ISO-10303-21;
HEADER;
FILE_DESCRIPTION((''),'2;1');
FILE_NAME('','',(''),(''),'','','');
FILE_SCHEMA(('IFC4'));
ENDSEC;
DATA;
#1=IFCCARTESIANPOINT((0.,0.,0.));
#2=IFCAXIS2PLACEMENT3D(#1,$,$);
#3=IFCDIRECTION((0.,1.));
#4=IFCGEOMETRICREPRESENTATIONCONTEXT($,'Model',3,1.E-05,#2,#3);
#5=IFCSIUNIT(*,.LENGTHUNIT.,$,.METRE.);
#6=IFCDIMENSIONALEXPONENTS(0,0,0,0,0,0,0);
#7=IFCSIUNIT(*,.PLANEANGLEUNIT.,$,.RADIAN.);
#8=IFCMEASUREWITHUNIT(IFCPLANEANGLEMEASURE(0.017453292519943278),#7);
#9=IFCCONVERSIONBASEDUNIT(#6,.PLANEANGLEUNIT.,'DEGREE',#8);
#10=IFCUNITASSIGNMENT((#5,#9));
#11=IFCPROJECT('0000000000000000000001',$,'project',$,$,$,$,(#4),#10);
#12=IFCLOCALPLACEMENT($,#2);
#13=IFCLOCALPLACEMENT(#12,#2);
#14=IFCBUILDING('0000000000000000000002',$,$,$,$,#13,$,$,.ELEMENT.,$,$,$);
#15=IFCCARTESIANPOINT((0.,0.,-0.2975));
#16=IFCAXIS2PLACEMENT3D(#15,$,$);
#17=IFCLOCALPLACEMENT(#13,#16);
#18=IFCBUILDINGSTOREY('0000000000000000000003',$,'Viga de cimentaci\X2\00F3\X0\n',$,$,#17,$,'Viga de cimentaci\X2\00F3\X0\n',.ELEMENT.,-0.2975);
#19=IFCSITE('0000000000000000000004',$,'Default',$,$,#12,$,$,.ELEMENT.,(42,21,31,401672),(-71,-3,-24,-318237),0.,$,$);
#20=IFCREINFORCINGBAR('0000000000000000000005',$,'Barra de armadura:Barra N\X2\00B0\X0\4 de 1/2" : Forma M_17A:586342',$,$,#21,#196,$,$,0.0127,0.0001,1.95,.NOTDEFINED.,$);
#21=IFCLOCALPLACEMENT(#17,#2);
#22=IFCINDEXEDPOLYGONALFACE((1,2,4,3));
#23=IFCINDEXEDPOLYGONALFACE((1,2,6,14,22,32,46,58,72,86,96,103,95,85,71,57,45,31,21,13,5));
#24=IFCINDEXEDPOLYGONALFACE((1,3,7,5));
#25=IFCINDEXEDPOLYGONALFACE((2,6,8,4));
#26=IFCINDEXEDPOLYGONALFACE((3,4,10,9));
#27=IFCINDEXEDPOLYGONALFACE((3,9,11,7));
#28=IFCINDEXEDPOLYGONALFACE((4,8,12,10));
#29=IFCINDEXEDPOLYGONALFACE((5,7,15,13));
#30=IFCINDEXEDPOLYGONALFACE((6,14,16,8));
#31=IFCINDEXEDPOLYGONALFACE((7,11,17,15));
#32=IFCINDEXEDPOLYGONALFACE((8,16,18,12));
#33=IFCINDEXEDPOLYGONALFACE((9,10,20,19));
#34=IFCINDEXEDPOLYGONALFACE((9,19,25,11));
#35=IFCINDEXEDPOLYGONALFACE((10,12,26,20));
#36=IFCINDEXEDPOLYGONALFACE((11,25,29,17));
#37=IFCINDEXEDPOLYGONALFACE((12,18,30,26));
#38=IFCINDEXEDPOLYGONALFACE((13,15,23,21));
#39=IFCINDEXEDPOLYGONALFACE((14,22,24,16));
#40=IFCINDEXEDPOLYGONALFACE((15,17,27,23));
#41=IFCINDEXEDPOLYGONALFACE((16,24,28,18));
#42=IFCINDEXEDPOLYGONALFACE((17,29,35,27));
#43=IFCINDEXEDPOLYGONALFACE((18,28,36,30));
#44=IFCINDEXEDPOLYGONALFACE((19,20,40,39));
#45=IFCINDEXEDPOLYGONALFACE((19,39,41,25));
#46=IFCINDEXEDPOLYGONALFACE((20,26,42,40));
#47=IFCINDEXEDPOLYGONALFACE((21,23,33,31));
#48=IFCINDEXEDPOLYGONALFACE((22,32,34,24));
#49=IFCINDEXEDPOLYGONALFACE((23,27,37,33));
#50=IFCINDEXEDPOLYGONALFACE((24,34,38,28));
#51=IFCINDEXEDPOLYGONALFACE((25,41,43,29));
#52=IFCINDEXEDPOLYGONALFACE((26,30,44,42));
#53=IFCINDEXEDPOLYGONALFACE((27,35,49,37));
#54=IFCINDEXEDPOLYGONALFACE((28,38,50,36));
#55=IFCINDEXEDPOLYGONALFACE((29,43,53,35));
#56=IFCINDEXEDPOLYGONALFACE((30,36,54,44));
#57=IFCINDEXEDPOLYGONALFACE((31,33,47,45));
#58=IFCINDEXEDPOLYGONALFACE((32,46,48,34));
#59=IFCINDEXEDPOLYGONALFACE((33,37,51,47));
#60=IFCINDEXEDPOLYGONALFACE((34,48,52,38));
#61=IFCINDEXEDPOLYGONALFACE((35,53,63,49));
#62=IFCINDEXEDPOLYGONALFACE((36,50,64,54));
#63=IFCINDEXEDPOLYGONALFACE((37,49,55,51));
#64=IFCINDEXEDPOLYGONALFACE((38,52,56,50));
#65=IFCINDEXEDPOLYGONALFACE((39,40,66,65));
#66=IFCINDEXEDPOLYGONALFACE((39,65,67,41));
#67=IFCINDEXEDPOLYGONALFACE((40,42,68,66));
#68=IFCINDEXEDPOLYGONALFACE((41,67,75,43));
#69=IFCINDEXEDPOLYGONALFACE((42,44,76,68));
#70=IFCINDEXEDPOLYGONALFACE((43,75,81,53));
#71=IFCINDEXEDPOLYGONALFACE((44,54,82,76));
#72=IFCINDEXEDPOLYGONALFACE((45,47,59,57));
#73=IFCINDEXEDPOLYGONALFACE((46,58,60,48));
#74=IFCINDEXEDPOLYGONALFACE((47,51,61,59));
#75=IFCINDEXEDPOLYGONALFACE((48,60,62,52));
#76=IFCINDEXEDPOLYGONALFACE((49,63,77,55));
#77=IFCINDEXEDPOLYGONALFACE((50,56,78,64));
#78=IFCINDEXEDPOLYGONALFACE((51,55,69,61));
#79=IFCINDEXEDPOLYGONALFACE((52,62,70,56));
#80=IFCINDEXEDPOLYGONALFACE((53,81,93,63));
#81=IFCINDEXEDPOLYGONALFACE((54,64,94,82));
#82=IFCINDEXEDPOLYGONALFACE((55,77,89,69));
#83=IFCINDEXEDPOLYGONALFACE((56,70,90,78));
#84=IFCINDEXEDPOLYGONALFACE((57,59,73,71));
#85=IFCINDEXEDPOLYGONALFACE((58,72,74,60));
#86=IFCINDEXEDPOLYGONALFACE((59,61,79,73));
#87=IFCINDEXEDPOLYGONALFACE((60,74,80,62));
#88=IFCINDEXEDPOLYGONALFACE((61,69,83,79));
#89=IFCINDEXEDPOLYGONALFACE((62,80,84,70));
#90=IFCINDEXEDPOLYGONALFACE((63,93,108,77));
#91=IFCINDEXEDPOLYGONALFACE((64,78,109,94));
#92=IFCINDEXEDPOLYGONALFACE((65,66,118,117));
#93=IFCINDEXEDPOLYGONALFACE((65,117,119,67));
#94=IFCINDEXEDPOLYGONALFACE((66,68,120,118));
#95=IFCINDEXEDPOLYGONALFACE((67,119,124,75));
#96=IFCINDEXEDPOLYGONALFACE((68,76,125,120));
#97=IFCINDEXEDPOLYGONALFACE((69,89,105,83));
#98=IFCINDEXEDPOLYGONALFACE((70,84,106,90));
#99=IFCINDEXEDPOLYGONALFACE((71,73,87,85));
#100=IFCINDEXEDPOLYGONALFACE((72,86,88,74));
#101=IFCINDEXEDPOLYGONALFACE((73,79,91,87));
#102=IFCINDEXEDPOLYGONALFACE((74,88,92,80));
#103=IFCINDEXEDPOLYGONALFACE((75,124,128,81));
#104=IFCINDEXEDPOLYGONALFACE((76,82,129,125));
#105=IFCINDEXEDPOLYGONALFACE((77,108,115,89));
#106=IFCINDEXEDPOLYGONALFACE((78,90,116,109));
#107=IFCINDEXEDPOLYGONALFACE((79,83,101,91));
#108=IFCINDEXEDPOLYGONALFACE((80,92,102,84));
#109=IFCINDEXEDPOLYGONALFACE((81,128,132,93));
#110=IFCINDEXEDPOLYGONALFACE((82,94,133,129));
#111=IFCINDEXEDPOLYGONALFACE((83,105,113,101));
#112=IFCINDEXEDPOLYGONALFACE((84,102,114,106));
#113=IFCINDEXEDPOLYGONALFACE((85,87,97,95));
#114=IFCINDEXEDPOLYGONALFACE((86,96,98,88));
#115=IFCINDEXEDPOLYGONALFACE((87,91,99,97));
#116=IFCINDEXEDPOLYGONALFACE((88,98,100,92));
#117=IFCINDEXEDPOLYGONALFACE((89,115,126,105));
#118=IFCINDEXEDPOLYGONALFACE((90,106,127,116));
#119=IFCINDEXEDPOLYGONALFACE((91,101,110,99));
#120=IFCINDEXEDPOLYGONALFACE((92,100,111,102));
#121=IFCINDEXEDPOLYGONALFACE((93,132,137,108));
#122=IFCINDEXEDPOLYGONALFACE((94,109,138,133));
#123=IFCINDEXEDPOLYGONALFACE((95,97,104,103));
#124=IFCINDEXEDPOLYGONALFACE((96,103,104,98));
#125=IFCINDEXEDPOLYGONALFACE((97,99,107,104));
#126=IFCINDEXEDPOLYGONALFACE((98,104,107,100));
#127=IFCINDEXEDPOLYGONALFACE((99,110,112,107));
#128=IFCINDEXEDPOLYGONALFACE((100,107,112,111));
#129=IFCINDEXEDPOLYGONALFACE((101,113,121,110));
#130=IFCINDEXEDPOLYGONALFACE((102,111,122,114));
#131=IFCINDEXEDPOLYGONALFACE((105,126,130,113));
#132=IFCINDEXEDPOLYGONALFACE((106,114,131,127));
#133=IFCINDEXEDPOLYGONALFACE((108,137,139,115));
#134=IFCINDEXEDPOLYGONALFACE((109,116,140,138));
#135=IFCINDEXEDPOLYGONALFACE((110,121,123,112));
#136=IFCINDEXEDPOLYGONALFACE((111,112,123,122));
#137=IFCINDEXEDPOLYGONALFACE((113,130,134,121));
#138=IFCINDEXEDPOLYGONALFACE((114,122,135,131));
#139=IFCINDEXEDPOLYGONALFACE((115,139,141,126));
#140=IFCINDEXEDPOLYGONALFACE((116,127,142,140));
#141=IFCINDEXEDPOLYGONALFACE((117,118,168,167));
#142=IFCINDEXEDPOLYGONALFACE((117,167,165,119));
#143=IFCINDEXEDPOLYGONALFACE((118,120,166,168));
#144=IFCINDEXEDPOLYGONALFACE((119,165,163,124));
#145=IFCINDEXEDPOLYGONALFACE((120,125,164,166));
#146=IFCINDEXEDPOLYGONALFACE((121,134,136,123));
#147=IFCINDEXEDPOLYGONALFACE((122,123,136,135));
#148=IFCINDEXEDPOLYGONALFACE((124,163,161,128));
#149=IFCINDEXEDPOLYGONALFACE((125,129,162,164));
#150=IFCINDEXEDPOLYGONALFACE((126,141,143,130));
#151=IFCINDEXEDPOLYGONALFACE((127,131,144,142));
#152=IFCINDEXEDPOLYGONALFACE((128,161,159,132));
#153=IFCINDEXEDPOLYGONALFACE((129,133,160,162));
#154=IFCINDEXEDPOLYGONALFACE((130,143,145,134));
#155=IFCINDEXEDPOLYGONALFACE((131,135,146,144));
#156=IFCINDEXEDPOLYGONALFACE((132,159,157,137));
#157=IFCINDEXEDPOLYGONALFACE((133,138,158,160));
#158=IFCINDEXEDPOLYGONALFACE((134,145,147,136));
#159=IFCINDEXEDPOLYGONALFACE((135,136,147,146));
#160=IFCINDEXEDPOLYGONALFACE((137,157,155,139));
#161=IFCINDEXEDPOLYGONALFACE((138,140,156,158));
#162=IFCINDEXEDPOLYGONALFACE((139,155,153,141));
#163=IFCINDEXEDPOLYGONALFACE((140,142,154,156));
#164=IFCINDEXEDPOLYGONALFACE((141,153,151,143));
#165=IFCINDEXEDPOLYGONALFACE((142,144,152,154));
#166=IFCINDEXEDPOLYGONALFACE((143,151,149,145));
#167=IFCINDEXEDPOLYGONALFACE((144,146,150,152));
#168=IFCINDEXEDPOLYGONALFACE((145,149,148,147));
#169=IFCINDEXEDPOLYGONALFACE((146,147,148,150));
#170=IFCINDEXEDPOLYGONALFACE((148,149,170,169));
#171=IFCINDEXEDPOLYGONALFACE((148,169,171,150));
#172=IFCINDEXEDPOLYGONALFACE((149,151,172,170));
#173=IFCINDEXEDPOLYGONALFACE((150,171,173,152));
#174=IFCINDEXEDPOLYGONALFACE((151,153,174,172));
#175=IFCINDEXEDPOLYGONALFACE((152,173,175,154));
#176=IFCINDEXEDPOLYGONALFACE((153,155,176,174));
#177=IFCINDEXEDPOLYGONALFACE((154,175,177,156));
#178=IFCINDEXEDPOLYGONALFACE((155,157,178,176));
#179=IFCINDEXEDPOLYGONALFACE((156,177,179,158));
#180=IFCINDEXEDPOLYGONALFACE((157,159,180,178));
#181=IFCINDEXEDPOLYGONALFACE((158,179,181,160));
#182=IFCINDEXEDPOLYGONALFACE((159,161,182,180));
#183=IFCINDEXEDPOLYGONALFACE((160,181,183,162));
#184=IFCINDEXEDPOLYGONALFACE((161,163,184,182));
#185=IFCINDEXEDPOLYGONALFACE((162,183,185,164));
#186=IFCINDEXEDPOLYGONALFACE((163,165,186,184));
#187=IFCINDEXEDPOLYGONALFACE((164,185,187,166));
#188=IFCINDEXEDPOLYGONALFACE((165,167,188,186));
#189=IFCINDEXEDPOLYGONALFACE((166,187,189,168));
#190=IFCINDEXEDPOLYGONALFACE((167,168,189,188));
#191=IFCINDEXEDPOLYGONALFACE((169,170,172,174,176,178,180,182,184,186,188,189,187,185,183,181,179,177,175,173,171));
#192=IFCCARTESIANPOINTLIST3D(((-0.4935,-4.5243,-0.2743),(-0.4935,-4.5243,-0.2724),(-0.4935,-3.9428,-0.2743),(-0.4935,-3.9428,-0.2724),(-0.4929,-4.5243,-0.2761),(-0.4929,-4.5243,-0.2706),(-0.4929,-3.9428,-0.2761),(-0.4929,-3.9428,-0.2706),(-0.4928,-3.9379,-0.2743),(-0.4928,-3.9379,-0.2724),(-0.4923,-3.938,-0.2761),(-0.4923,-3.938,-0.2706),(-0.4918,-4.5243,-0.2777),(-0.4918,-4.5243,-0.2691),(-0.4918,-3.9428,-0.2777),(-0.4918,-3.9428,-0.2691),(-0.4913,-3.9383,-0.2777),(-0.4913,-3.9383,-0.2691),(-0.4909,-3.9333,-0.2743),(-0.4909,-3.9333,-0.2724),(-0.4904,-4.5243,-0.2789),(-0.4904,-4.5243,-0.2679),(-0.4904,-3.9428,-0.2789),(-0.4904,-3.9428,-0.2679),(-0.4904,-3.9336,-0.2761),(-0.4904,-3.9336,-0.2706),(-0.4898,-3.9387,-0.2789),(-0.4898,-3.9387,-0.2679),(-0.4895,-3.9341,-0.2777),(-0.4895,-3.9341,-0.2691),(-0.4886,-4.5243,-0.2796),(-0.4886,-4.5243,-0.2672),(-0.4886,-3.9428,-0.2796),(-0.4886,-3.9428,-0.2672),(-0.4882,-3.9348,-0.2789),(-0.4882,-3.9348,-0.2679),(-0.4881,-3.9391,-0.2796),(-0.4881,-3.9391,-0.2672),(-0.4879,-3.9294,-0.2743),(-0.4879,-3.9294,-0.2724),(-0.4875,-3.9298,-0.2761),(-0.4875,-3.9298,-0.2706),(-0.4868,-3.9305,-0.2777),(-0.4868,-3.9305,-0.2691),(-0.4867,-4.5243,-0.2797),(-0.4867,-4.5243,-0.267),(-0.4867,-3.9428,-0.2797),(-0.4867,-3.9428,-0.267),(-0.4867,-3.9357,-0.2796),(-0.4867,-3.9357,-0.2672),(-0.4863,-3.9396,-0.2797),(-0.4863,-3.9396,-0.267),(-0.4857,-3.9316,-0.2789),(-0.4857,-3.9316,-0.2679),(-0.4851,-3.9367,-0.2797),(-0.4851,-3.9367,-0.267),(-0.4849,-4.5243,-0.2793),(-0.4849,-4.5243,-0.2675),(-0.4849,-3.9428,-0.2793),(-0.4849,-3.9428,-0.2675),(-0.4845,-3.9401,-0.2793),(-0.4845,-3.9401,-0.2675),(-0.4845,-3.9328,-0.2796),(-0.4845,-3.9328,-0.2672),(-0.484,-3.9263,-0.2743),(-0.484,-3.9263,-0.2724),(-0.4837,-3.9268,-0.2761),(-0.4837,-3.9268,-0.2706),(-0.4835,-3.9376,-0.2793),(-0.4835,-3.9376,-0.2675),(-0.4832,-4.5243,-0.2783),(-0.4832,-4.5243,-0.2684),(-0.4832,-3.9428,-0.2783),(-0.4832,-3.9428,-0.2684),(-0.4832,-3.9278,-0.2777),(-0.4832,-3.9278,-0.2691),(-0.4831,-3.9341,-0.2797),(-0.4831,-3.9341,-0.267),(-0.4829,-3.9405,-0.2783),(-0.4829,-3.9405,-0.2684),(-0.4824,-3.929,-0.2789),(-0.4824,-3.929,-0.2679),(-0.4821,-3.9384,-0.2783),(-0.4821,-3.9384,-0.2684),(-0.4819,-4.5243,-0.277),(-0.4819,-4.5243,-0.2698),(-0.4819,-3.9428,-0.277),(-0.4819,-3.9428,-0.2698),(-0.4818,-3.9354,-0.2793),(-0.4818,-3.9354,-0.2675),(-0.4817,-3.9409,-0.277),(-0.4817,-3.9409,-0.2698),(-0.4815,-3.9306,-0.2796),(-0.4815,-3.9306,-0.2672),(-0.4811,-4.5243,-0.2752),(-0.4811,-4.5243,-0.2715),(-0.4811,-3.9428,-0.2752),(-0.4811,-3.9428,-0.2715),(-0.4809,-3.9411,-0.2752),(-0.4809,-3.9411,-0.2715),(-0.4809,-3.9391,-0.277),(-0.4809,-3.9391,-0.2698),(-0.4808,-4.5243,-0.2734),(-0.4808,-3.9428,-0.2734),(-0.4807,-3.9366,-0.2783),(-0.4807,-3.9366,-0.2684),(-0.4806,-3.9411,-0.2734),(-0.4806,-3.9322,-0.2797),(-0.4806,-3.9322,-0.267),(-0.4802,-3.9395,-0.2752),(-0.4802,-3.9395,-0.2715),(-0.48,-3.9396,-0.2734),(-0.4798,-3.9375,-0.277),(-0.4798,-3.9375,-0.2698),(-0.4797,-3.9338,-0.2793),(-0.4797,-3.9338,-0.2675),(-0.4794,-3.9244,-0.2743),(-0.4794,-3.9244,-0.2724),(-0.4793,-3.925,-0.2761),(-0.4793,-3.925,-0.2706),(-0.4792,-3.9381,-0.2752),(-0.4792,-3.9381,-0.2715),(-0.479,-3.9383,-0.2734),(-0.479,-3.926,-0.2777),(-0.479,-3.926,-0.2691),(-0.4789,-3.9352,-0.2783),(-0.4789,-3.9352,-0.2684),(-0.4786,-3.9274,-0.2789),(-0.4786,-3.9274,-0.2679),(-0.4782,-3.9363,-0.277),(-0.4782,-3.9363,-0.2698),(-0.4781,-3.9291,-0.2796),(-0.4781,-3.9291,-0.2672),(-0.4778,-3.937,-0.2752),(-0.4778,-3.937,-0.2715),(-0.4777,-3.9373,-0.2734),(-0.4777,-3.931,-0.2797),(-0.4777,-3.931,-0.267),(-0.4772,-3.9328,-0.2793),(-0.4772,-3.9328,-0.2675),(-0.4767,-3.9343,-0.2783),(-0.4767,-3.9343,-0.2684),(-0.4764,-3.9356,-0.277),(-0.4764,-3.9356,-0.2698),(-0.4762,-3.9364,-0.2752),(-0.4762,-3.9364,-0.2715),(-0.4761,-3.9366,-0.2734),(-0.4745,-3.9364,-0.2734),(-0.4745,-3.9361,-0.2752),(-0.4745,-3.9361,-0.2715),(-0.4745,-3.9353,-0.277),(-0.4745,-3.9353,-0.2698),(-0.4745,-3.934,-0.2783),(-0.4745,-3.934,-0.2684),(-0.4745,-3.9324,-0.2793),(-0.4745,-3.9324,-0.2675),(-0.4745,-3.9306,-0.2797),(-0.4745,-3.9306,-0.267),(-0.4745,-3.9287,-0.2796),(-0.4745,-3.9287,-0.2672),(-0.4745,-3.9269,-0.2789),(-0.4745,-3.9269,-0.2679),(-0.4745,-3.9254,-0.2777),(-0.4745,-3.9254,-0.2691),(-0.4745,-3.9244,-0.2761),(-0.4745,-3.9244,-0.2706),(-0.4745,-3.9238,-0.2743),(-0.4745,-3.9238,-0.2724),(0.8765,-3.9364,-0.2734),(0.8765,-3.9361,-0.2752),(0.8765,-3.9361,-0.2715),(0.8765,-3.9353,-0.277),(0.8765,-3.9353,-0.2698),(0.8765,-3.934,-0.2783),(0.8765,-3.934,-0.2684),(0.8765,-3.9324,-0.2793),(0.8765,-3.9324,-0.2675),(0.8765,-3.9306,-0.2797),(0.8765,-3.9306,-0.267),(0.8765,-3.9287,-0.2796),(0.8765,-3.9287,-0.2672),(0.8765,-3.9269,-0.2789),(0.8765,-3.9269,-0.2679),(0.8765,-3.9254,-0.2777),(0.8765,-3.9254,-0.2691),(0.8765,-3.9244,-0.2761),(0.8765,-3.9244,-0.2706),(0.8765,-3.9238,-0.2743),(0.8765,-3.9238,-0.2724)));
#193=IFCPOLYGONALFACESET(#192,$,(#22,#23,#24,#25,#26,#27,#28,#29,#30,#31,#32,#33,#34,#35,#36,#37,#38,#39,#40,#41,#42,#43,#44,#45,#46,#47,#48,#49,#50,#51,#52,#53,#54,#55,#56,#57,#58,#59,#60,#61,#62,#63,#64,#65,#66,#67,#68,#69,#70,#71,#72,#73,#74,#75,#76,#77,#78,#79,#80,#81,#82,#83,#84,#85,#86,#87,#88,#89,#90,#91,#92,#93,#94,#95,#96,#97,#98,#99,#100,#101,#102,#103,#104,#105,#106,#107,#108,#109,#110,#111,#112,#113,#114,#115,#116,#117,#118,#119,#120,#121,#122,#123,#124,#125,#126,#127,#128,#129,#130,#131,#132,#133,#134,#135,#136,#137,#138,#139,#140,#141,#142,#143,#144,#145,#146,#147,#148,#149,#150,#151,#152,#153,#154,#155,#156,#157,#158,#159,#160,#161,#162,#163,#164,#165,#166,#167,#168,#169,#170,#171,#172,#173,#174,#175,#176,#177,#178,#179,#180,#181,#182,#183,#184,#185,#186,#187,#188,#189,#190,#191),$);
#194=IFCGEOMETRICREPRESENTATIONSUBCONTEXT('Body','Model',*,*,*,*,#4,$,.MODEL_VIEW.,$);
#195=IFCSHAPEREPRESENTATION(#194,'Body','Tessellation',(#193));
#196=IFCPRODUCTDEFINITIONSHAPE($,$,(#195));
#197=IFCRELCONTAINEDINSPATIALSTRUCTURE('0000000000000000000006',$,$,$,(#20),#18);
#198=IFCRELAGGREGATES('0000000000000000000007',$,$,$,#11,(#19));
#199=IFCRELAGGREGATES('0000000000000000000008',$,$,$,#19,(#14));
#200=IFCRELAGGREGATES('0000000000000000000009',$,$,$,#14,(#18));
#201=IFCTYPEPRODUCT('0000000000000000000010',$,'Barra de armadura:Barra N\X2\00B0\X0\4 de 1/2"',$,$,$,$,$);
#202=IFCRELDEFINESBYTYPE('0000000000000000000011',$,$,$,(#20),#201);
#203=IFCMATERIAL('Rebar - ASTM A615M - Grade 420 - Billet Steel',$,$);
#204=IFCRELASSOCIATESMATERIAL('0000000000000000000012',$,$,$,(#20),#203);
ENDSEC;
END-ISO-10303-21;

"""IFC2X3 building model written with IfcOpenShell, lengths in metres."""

from ifc_helpers import new_model, entity, si_unit, converted_unit, direction, frame, origin, place, context, subcontext, project, spatial, material, type_object, element, save


model = new_model("IFC2X3")

# Units and contexts
model_context = context("Model", 3, precision=1e-05, world=origin(), true_north=direction((0.0, 1.0)))
body_context = subcontext(model_context, "Body", "Model", "MODEL_VIEW")
ifc_project = project(units=[si_unit("LENGTHUNIT", "METRE"), converted_unit("PLANEANGLEUNIT", "DEGREE", entity("IfcPlaneAngleMeasure", 0.017453292519943278), si_unit("PLANEANGLEUNIT", "RADIAN"), dimensions=[0, 0, 0, 0, 0, 0, 0])], contexts=[model_context])

# Site, building, storey
site_placement = place(None, origin())
site = spatial("IfcSite", under=ifc_project, at=site_placement, Name="Default", CompositionType="ELEMENT", RefLatitude=(42, 21, 31, 401672), RefLongitude=(-71, -3, -24, -318237), RefElevation=0.0)
building_placement = place(site_placement, origin())
building = spatial("IfcBuilding", under=site, at=building_placement, CompositionType="ELEMENT")
storey_placement = place(building_placement, frame((0.0, 0.0, -0.2975)))
storey = spatial("IfcBuildingStorey", under=building, at=storey_placement, Name="Viga de cimentación", LongName="Viga de cimentación", CompositionType="ELEMENT", Elevation=-0.2975)

# Reinforcing bar
ifc_material = material(Name="Rebar - ASTM A615M - Grade 420 - Billet Steel")
type_product_1 = type_object("IfcTypeProduct", Name="Barra de armadura:Barra N°4 de 1/2\"")
reinforcing_bar_1_placement = place(storey_placement, origin())
element("IfcReinforcingBar", 1, at=reinforcing_bar_1_placement, inside=storey, type_object=type_product_1, material=ifc_material, Name="Barra de armadura:Barra N°4 de 1/2\" : Forma M_17A:586342", BarLength=1.95, BarRole="NOTDEFINED", CrossSectionArea=0.0001, NominalDiameter=0.0127, context=body_context, shape_type="AdvancedSweptSolid", body=[
    entity("IfcSweptDiskSolid", entity("IfcCompositeCurve", [entity("IfcCompositeCurveSegment", "CONTINUOUS", True, entity("IfcPolyline", [entity("IfcCartesianPoint", [-0.4872, -4.5243, -0.2734]), entity("IfcCartesianPoint", [-0.4872, -3.9428, -0.2734])])), entity("IfcCompositeCurveSegment", "CONTINUOUS", True, entity("IfcTrimmedCurve", entity("IfcCircle", entity("IfcAxis2Placement3D", entity("IfcCartesianPoint", [-0.4745, -3.9428, -0.2734]), entity("IfcDirection", [0.0, 0.0, -1.0]), entity("IfcDirection", [0.0, 1.0, 0.0])), 0.0127), [entity("IfcParameterValue", 270.0)], [entity("IfcParameterValue", 360.0)], True, "PARAMETER")), entity("IfcCompositeCurveSegment", "CONTINUOUS", True, entity("IfcPolyline", [entity("IfcCartesianPoint", [-0.4745, -3.9301, -0.2734]), entity("IfcCartesianPoint", [0.8765, -3.9301, -0.2734])]))], False), 0.0063, None, 0.0, 92.0),
])

save(model, "model.ifc")
